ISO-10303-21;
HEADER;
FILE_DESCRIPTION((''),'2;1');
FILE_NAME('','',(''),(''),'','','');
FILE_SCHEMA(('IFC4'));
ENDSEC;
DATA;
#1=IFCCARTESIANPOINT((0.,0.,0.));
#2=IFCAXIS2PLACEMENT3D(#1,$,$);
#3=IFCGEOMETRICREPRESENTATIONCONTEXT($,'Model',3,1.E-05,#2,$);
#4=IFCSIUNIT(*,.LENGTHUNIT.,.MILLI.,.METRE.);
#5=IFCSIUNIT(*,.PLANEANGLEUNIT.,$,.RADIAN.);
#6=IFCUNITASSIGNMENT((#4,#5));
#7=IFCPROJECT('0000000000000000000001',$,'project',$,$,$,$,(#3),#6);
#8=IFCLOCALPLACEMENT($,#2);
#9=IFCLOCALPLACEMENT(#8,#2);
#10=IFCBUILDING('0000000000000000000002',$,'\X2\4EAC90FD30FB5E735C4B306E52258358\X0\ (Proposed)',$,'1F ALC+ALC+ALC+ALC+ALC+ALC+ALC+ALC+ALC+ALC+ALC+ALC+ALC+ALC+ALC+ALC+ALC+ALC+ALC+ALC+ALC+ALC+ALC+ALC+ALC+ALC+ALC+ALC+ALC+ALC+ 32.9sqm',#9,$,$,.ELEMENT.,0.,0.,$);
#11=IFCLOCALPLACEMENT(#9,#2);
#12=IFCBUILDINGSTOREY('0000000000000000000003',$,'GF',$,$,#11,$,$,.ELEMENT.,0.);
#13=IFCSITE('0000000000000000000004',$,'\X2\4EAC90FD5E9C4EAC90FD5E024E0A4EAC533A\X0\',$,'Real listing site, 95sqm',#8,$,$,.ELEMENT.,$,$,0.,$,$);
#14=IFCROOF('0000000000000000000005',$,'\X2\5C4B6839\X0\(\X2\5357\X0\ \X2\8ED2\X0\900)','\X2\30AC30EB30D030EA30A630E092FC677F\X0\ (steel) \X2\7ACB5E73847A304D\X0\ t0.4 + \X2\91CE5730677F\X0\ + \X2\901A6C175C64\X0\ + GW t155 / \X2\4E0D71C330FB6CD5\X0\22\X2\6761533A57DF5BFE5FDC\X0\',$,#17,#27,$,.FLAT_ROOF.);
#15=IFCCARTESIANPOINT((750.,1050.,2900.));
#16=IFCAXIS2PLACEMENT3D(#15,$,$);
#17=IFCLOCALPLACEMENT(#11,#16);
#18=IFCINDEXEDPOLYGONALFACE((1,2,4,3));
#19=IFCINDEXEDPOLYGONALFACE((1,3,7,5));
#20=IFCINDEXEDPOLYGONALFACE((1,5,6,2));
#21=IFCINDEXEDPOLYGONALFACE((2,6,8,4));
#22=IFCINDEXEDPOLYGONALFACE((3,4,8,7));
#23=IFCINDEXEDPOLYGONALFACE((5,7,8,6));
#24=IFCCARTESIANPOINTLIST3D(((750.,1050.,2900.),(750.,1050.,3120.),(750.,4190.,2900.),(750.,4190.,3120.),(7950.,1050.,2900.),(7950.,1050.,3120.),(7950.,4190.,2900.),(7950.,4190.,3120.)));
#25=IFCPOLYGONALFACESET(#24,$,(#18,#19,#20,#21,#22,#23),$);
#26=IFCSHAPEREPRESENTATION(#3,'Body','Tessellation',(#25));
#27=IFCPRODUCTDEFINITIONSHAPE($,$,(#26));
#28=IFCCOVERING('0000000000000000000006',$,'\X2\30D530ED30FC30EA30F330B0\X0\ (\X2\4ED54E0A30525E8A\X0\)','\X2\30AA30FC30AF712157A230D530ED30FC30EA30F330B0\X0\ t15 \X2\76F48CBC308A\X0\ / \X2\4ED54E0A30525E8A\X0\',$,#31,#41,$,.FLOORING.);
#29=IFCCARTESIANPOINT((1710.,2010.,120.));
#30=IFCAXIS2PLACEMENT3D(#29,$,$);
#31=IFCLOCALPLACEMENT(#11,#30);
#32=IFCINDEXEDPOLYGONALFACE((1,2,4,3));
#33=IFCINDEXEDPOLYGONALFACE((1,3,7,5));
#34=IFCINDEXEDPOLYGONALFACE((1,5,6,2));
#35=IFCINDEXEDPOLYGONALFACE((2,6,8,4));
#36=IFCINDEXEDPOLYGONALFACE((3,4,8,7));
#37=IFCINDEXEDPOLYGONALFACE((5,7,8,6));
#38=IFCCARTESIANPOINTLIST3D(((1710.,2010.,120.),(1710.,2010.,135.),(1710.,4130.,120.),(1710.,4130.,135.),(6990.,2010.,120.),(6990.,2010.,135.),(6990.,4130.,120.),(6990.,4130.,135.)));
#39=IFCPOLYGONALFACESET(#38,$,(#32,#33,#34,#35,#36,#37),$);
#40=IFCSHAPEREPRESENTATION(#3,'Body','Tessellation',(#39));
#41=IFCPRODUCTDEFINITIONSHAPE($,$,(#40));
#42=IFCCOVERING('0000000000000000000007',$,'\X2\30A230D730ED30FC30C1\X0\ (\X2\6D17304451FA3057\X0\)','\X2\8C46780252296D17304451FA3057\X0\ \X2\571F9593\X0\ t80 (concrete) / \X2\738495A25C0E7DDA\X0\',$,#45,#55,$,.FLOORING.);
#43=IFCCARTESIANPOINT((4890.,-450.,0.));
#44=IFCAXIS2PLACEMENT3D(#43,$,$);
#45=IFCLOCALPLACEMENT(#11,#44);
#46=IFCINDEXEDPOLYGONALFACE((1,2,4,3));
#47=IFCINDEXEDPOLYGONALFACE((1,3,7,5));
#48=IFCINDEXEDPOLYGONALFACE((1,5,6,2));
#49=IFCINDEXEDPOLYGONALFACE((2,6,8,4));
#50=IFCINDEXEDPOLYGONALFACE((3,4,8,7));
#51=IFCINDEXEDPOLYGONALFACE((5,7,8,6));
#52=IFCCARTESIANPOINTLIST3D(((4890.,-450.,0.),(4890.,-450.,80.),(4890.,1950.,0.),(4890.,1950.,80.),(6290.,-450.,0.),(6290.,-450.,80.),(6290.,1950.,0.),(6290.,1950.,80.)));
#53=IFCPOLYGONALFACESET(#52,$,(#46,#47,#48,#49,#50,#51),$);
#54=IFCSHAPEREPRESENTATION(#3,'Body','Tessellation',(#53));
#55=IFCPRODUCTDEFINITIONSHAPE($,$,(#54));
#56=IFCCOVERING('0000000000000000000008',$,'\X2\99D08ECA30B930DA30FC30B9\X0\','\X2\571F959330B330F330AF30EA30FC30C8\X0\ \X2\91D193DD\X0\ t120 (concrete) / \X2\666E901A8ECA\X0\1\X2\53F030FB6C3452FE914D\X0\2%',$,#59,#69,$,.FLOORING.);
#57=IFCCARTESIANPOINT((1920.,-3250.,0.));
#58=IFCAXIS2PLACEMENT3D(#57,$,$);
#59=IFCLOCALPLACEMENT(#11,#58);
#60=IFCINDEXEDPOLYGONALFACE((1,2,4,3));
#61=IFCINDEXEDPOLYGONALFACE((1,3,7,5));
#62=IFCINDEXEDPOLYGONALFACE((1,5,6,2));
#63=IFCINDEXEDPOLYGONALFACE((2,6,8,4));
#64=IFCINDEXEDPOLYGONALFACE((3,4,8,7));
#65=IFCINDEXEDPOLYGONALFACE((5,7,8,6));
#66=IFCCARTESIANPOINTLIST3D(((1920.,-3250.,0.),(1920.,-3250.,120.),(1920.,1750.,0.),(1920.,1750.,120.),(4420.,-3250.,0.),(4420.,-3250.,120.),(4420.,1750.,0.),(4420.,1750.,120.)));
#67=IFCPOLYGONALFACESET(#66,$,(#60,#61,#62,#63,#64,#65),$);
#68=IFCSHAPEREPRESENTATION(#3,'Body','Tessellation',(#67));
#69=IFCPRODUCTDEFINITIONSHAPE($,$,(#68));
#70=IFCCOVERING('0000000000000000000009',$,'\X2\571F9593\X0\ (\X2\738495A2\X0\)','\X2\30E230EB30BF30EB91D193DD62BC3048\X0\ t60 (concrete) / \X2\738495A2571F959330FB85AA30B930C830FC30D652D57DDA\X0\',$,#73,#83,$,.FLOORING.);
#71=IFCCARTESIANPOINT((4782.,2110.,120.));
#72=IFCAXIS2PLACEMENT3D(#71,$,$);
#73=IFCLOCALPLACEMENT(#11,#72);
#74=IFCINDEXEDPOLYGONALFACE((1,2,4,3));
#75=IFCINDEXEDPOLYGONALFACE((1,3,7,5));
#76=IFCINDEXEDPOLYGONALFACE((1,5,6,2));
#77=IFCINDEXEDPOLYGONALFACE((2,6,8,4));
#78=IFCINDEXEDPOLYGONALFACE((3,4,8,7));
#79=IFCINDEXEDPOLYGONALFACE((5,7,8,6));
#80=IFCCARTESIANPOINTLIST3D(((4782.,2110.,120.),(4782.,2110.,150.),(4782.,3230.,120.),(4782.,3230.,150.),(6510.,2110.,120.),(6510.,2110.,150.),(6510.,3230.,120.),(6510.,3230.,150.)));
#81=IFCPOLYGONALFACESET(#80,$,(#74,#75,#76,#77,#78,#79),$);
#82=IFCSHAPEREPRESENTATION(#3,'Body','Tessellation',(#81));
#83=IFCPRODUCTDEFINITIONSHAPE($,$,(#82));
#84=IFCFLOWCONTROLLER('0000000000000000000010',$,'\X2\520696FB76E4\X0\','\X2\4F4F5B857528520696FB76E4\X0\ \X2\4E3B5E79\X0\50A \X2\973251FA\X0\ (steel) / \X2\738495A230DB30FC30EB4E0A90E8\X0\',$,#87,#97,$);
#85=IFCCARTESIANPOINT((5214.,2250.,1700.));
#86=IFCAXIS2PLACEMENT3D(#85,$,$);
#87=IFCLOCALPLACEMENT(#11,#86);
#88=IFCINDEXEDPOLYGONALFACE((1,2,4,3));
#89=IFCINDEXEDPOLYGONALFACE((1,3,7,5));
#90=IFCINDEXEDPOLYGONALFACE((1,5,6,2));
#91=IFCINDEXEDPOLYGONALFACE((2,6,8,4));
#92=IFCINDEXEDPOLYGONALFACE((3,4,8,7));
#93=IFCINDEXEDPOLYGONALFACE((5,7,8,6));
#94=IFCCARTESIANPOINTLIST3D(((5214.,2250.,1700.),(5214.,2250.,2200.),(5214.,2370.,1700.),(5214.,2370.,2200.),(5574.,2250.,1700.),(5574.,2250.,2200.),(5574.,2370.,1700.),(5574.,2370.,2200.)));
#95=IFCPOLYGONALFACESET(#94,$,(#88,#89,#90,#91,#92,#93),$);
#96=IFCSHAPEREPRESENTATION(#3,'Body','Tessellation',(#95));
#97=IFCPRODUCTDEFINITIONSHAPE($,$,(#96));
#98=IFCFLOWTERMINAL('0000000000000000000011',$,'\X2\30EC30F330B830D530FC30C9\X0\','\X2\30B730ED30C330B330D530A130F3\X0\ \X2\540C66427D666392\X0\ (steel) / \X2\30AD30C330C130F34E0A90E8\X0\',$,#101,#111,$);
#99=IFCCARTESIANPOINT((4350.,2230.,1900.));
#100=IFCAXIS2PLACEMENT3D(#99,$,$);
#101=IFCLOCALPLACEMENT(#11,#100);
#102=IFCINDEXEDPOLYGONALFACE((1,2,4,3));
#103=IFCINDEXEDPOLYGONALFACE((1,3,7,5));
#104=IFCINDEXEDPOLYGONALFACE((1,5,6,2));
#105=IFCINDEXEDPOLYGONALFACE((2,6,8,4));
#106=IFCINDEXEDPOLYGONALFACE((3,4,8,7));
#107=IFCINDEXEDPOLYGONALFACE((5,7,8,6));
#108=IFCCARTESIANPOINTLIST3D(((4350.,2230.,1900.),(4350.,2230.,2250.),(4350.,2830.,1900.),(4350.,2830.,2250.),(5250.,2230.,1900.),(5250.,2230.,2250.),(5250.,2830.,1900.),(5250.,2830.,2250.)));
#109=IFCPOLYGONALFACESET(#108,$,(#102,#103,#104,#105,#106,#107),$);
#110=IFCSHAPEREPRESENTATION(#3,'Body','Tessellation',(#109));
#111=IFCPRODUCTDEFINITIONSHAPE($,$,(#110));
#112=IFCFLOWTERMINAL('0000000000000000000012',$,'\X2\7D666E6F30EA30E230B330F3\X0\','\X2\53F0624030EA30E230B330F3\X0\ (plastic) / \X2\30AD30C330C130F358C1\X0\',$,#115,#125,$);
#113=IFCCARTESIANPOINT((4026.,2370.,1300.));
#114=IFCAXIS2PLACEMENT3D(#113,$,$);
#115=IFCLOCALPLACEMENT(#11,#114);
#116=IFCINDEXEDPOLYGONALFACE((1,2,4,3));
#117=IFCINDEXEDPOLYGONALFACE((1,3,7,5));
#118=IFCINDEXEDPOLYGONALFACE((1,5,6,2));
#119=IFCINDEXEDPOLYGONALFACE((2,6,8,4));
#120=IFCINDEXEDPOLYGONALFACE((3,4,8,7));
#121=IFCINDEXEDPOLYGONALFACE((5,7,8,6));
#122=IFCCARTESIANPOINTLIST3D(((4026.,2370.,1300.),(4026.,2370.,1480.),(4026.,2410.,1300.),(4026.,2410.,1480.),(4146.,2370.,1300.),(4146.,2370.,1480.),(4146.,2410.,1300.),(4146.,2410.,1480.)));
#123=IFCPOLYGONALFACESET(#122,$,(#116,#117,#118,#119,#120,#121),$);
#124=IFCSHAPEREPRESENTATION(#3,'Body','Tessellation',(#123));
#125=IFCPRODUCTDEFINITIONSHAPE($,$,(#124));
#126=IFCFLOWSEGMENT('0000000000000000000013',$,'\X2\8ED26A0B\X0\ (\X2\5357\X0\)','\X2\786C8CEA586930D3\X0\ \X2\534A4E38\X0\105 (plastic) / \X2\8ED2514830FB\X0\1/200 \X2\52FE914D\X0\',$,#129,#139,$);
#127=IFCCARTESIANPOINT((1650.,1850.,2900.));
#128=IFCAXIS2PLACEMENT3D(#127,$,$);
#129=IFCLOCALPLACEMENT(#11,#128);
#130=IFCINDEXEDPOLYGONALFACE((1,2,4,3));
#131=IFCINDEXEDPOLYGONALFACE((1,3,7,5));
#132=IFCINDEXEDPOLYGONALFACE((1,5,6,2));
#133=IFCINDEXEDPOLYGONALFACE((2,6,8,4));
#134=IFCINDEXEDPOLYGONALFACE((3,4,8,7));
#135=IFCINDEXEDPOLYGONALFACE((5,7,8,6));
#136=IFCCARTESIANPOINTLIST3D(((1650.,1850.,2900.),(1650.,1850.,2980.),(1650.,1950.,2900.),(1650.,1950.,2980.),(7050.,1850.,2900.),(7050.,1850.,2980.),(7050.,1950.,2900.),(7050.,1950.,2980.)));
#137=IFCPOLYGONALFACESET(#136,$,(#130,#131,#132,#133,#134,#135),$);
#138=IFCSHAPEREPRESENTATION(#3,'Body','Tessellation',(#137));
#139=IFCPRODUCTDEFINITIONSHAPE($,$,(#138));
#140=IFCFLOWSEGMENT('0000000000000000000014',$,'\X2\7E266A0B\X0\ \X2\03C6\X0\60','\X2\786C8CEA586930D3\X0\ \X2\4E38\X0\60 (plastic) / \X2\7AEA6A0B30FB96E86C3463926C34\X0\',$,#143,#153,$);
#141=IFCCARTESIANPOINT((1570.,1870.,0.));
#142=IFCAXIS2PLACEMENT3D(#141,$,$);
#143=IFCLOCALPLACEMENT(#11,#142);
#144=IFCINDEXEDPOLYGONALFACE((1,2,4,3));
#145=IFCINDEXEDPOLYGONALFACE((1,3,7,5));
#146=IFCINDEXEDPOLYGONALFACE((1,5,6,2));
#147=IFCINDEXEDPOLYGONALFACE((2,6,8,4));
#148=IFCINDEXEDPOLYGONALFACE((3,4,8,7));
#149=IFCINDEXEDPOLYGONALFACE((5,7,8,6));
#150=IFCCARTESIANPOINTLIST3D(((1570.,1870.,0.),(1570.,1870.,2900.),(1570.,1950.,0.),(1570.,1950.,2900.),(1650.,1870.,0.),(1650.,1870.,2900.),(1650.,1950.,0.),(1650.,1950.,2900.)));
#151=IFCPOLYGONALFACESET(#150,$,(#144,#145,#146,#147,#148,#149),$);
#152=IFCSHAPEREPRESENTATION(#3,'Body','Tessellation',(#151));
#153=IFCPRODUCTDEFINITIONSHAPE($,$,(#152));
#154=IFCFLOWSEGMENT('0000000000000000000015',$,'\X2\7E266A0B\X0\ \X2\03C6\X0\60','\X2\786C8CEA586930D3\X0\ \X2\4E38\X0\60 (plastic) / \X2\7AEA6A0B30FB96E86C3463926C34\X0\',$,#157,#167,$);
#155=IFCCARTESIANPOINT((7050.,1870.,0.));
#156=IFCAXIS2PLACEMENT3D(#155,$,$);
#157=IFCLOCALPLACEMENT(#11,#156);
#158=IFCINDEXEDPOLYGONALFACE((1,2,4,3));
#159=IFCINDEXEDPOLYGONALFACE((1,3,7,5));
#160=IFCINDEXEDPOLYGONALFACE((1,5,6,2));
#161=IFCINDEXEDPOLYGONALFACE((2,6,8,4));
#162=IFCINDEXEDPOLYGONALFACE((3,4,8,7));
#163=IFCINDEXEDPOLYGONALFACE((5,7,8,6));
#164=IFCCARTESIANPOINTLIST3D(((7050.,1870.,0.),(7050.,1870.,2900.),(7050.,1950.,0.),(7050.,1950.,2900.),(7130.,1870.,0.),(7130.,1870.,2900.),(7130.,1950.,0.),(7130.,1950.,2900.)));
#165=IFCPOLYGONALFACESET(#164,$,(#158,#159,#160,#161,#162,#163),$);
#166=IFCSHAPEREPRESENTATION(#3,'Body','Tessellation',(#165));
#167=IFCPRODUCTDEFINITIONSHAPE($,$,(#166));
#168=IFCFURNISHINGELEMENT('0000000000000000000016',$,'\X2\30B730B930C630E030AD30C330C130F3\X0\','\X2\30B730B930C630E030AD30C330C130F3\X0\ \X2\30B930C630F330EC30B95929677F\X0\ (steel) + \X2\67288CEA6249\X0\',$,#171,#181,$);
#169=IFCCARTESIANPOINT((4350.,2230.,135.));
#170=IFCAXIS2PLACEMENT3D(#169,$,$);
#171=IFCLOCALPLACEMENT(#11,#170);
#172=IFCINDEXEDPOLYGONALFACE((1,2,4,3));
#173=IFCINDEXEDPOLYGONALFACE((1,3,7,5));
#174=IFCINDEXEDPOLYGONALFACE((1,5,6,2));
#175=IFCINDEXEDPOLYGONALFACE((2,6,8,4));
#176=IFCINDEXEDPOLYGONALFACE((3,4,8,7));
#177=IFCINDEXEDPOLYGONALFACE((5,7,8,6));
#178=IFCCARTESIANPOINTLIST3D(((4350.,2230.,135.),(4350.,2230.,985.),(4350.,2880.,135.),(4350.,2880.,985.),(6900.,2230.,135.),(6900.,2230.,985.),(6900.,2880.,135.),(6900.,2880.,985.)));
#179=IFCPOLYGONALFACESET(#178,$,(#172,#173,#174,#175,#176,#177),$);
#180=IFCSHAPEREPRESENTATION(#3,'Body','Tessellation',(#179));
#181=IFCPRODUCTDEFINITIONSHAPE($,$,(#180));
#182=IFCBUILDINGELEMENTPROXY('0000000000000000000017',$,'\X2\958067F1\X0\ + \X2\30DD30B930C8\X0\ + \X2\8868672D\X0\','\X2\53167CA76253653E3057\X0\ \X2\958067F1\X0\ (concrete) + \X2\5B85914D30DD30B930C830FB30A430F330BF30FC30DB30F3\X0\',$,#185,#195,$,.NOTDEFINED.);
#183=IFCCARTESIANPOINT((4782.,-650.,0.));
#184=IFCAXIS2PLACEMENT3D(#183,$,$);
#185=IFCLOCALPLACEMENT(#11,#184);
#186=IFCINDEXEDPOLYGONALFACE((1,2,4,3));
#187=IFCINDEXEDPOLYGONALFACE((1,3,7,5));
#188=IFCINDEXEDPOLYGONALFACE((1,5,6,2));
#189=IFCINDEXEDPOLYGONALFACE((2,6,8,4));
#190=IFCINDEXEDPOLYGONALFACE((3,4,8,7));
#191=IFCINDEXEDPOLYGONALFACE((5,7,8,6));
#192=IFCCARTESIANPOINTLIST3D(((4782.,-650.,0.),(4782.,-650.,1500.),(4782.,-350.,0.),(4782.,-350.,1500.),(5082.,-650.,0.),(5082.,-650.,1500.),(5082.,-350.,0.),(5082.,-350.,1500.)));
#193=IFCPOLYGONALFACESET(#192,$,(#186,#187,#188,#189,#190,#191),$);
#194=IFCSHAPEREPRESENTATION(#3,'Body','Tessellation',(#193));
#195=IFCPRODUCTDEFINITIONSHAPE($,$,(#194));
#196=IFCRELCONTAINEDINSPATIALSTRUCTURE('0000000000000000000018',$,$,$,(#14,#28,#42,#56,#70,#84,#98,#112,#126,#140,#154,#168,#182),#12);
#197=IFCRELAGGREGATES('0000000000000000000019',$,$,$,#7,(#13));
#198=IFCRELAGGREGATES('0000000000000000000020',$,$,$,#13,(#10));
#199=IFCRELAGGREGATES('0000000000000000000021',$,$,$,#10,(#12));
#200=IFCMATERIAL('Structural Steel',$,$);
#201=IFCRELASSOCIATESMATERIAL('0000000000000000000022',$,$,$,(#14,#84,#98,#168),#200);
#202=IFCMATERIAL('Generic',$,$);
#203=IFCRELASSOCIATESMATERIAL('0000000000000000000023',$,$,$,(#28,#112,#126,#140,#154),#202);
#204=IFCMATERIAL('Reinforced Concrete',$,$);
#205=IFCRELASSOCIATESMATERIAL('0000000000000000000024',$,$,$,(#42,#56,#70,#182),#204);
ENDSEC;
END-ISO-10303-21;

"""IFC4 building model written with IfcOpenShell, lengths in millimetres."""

from ifc_helpers import new_model, si_unit, frame, frame_2d, origin, place, context, project, spatial, rectangle, extrude, material, element, save


model = new_model("IFC4")

# Units and contexts
model_context = context("Model", 3, precision=1e-05, world=origin())
ifc_project = project(units=[si_unit("LENGTHUNIT", "METRE", prefix="MILLI"), si_unit("PLANEANGLEUNIT", "RADIAN")], contexts=[model_context])

# Site, building, storey
site_placement = place(None, origin())
site = spatial("IfcSite", under=ifc_project, at=site_placement, Name="京都府京都市上京区", ObjectType="Real listing site, 95sqm", CompositionType="ELEMENT", RefElevation=0.0)
building_placement = place(site_placement, origin())
building = spatial("IfcBuilding", under=site, at=building_placement, Name="京都・平屋の別荘 (Proposed)", ObjectType="1F ALC+ALC+ALC+ALC+ALC+ALC+ALC+ALC+ALC+ALC+ALC+ALC+ALC+ALC+ALC+ALC+ALC+ALC+ALC+ALC+ALC+ALC+ALC+ALC+ALC+ALC+ALC+ALC+ALC+ALC+ 32.9sqm", CompositionType="ELEMENT", ElevationOfRefHeight=0.0, ElevationOfTerrain=0.0)
storey_placement = place(building_placement, origin())
storey = spatial("IfcBuildingStorey", under=building, at=storey_placement, Name="GF", CompositionType="ELEMENT", Elevation=0.0)

# Shared definitions
ifc_material_1 = material(Name="Reinforced Concrete")

# Roof
ifc_material_2 = material(Name="Structural Steel")
roof_placement = place(storey_placement, frame((750.0, 1050.0, 2900.0)))
element("IfcRoof", 1, at=roof_placement, inside=storey, material=ifc_material_2, Name="屋根(南 軒900)", Description="ガルバリウム鋼板 (steel) 立平葺き t0.4 + 野地板 + 通気層 + GW t155 / 不燃・法22条区域対応", PredefinedType="FLAT_ROOF", context=model_context, shape_type="SweptSolid", body=[
    extrude(rectangle(XDim=7200.0, YDim=3140.0, at=frame_2d((3600.0, 1570.0))), frame((750.0, 1050.0, 2900.0)), (0.0, 0.0, 1.0), 220.0),
])

# Coverings
ifc_material_3 = material(Name="Generic")
covering_1_placement = place(storey_placement, frame((1710.0, 2010.0, 120.0)))
element("IfcCovering", 2, at=covering_1_placement, inside=storey, material=ifc_material_3, Name="フローリング (仕上げ床)", Description="オーク無垢フローリング t15 直貼り / 仕上げ床", PredefinedType="FLOORING", context=model_context, shape_type="SweptSolid", body=[
    extrude(rectangle(XDim=5280.0, YDim=2120.0, at=frame_2d((2640.0, 1060.0))), frame((1710.0, 2010.0, 120.0)), (0.0, 0.0, 1.0), 15.0),
])
covering_2_placement = place(storey_placement, frame((4890.0, -450.0, 0.0)))
element("IfcCovering", 3, at=covering_2_placement, inside=storey, material=ifc_material_1, Name="アプローチ (洗い出し)", Description="豆砂利洗い出し 土間 t80 (concrete) / 玄関導線", PredefinedType="FLOORING", context=model_context, shape_type="SweptSolid", body=[
    extrude(rectangle(XDim=1400.0, YDim=2400.0, at=frame_2d((700.0, 1200.0))), frame((4890.0, -450.0, 0.0)), (0.0, 0.0, 1.0), 80.0),
])
covering_3_placement = place(storey_placement, frame((1920.0, -3250.0, 0.0)))
element("IfcCovering", 4, at=covering_3_placement, inside=storey, material=ifc_material_1, Name="駐車スペース", Description="土間コンクリート 金鏝 t120 (concrete) / 普通車1台・水勾配2%", PredefinedType="FLOORING", context=model_context, shape_type="SweptSolid", body=[
    extrude(rectangle(XDim=2500.0, YDim=5000.0, at=frame_2d((1250.0, 2500.0))), frame((1920.0, -3250.0, 0.0)), (0.0, 0.0, 1.0), 120.0),
])
covering_4_placement = place(storey_placement, frame((4782.0, 2110.0, 120.0)))
element("IfcCovering", 5, at=covering_4_placement, inside=storey, material=ifc_material_1, Name="土間 (玄関)", Description="モルタル金鏝押え t60 (concrete) / 玄関土間・薪ストーブ動線", PredefinedType="FLOORING", context=model_context, shape_type="SweptSolid", body=[
    extrude(rectangle(XDim=1728.0, YDim=1120.0, at=frame_2d((864.0, 560.0))), frame((4782.0, 2110.0, 120.0)), (0.0, 0.0, 1.0), 30.0),
])

# Flow controller
flow_controller_placement = place(storey_placement, frame((5214.0, 2250.0, 1700.0)))
element("IfcFlowController", 6, at=flow_controller_placement, inside=storey, material=ifc_material_2, Name="分電盤", Description="住宅用分電盤 主幹50A 露出 (steel) / 玄関ホール上部", context=model_context, shape_type="SweptSolid", body=[
    extrude(rectangle(XDim=360.0, YDim=120.0, at=frame_2d((180.0, 60.0))), frame((5214.0, 2250.0, 1700.0)), (0.0, 0.0, 1.0), 500.0),
])

# Flow terminals
flow_terminal_1_placement = place(storey_placement, frame((4350.0, 2230.0, 1900.0)))
element("IfcFlowTerminal", 7, at=flow_terminal_1_placement, inside=storey, material=ifc_material_2, Name="レンジフード", Description="シロッコファン 同時給排 (steel) / キッチン上部", context=model_context, shape_type="SweptSolid", body=[
    extrude(rectangle(XDim=900.0, YDim=600.0, at=frame_2d((450.0, 300.0))), frame((4350.0, 2230.0, 1900.0)), (0.0, 0.0, 1.0), 350.0),
])
flow_terminal_2_placement = place(storey_placement, frame((4026.0, 2370.0, 1300.0)))
element("IfcFlowTerminal", 8, at=flow_terminal_2_placement, inside=storey, material=ifc_material_3, Name="給湯リモコン", Description="台所リモコン (plastic) / キッチン壁", context=model_context, shape_type="SweptSolid", body=[
    extrude(rectangle(XDim=120.0, YDim=40.0, at=frame_2d((60.0, 20.0))), frame((4026.0, 2370.0, 1300.0)), (0.0, 0.0, 1.0), 180.0),
])

# Flow segments
flow_segment_1_placement = place(storey_placement, frame((1650.0, 1850.0, 2900.0)))
element("IfcFlowSegment", 9, at=flow_segment_1_placement, inside=storey, material=ifc_material_3, Name="軒樋 (南)", Description="硬質塩ビ 半丸105 (plastic) / 軒先・1/200 勾配", context=model_context, shape_type="SweptSolid", body=[
    extrude(rectangle(XDim=5400.0, YDim=100.0, at=frame_2d((2700.0, 50.0))), frame((1650.0, 1850.0, 2900.0)), (0.0, 0.0, 1.0), 80.0),
])
flow_segment_2_placement = place(storey_placement, frame((1570.0, 1870.0, 0.0)))
element("IfcFlowSegment", 10, at=flow_segment_2_placement, inside=storey, material=ifc_material_3, Name="縦樋 φ60", Description="硬質塩ビ 丸60 (plastic) / 竪樋・雨水排水", context=model_context, shape_type="SweptSolid", body=[
    extrude(rectangle(XDim=80.0, YDim=80.0, at=frame_2d((40.0, 40.0))), frame((1570.0, 1870.0, 0.0)), (0.0, 0.0, 1.0), 2900.0),
])
flow_segment_3_placement = place(storey_placement, frame((7050.0, 1870.0, 0.0)))
element("IfcFlowSegment", 11, at=flow_segment_3_placement, inside=storey, material=ifc_material_3, Name="縦樋 φ60", Description="硬質塩ビ 丸60 (plastic) / 竪樋・雨水排水", context=model_context, shape_type="SweptSolid", body=[
    extrude(rectangle(XDim=80.0, YDim=80.0, at=frame_2d((40.0, 40.0))), frame((7050.0, 1870.0, 0.0)), (0.0, 0.0, 1.0), 2900.0),
])

# Furnishing element
furnishing_placement = place(storey_placement, frame((4350.0, 2230.0, 135.0)))
element("IfcFurnishingElement", 12, at=furnishing_placement, inside=storey, material=ifc_material_2, Name="システムキッチン", Description="システムキッチン ステンレス天板 (steel) + 木質扉", context=model_context, shape_type="SweptSolid", body=[
    extrude(rectangle(XDim=2550.0, YDim=650.0, at=frame_2d((1275.0, 325.0))), frame((4350.0, 2230.0, 135.0)), (0.0, 0.0, 1.0), 850.0),
])

# Building element proxy
proxy_placement = place(storey_placement, frame((4782.0, -650.0, 0.0)))
element("IfcBuildingElementProxy", 13, at=proxy_placement, inside=storey, material=ifc_material_1, Name="門柱 + ポスト + 表札", Description="化粧打放し 門柱 (concrete) + 宅配ポスト・インターホン", PredefinedType="NOTDEFINED", context=model_context, shape_type="SweptSolid", body=[
    extrude(rectangle(XDim=300.0, YDim=300.0, at=frame_2d((150.0, 150.0))), frame((4782.0, -650.0, 0.0)), (0.0, 0.0, 1.0), 1500.0),
])

save(model, "model.ifc")
